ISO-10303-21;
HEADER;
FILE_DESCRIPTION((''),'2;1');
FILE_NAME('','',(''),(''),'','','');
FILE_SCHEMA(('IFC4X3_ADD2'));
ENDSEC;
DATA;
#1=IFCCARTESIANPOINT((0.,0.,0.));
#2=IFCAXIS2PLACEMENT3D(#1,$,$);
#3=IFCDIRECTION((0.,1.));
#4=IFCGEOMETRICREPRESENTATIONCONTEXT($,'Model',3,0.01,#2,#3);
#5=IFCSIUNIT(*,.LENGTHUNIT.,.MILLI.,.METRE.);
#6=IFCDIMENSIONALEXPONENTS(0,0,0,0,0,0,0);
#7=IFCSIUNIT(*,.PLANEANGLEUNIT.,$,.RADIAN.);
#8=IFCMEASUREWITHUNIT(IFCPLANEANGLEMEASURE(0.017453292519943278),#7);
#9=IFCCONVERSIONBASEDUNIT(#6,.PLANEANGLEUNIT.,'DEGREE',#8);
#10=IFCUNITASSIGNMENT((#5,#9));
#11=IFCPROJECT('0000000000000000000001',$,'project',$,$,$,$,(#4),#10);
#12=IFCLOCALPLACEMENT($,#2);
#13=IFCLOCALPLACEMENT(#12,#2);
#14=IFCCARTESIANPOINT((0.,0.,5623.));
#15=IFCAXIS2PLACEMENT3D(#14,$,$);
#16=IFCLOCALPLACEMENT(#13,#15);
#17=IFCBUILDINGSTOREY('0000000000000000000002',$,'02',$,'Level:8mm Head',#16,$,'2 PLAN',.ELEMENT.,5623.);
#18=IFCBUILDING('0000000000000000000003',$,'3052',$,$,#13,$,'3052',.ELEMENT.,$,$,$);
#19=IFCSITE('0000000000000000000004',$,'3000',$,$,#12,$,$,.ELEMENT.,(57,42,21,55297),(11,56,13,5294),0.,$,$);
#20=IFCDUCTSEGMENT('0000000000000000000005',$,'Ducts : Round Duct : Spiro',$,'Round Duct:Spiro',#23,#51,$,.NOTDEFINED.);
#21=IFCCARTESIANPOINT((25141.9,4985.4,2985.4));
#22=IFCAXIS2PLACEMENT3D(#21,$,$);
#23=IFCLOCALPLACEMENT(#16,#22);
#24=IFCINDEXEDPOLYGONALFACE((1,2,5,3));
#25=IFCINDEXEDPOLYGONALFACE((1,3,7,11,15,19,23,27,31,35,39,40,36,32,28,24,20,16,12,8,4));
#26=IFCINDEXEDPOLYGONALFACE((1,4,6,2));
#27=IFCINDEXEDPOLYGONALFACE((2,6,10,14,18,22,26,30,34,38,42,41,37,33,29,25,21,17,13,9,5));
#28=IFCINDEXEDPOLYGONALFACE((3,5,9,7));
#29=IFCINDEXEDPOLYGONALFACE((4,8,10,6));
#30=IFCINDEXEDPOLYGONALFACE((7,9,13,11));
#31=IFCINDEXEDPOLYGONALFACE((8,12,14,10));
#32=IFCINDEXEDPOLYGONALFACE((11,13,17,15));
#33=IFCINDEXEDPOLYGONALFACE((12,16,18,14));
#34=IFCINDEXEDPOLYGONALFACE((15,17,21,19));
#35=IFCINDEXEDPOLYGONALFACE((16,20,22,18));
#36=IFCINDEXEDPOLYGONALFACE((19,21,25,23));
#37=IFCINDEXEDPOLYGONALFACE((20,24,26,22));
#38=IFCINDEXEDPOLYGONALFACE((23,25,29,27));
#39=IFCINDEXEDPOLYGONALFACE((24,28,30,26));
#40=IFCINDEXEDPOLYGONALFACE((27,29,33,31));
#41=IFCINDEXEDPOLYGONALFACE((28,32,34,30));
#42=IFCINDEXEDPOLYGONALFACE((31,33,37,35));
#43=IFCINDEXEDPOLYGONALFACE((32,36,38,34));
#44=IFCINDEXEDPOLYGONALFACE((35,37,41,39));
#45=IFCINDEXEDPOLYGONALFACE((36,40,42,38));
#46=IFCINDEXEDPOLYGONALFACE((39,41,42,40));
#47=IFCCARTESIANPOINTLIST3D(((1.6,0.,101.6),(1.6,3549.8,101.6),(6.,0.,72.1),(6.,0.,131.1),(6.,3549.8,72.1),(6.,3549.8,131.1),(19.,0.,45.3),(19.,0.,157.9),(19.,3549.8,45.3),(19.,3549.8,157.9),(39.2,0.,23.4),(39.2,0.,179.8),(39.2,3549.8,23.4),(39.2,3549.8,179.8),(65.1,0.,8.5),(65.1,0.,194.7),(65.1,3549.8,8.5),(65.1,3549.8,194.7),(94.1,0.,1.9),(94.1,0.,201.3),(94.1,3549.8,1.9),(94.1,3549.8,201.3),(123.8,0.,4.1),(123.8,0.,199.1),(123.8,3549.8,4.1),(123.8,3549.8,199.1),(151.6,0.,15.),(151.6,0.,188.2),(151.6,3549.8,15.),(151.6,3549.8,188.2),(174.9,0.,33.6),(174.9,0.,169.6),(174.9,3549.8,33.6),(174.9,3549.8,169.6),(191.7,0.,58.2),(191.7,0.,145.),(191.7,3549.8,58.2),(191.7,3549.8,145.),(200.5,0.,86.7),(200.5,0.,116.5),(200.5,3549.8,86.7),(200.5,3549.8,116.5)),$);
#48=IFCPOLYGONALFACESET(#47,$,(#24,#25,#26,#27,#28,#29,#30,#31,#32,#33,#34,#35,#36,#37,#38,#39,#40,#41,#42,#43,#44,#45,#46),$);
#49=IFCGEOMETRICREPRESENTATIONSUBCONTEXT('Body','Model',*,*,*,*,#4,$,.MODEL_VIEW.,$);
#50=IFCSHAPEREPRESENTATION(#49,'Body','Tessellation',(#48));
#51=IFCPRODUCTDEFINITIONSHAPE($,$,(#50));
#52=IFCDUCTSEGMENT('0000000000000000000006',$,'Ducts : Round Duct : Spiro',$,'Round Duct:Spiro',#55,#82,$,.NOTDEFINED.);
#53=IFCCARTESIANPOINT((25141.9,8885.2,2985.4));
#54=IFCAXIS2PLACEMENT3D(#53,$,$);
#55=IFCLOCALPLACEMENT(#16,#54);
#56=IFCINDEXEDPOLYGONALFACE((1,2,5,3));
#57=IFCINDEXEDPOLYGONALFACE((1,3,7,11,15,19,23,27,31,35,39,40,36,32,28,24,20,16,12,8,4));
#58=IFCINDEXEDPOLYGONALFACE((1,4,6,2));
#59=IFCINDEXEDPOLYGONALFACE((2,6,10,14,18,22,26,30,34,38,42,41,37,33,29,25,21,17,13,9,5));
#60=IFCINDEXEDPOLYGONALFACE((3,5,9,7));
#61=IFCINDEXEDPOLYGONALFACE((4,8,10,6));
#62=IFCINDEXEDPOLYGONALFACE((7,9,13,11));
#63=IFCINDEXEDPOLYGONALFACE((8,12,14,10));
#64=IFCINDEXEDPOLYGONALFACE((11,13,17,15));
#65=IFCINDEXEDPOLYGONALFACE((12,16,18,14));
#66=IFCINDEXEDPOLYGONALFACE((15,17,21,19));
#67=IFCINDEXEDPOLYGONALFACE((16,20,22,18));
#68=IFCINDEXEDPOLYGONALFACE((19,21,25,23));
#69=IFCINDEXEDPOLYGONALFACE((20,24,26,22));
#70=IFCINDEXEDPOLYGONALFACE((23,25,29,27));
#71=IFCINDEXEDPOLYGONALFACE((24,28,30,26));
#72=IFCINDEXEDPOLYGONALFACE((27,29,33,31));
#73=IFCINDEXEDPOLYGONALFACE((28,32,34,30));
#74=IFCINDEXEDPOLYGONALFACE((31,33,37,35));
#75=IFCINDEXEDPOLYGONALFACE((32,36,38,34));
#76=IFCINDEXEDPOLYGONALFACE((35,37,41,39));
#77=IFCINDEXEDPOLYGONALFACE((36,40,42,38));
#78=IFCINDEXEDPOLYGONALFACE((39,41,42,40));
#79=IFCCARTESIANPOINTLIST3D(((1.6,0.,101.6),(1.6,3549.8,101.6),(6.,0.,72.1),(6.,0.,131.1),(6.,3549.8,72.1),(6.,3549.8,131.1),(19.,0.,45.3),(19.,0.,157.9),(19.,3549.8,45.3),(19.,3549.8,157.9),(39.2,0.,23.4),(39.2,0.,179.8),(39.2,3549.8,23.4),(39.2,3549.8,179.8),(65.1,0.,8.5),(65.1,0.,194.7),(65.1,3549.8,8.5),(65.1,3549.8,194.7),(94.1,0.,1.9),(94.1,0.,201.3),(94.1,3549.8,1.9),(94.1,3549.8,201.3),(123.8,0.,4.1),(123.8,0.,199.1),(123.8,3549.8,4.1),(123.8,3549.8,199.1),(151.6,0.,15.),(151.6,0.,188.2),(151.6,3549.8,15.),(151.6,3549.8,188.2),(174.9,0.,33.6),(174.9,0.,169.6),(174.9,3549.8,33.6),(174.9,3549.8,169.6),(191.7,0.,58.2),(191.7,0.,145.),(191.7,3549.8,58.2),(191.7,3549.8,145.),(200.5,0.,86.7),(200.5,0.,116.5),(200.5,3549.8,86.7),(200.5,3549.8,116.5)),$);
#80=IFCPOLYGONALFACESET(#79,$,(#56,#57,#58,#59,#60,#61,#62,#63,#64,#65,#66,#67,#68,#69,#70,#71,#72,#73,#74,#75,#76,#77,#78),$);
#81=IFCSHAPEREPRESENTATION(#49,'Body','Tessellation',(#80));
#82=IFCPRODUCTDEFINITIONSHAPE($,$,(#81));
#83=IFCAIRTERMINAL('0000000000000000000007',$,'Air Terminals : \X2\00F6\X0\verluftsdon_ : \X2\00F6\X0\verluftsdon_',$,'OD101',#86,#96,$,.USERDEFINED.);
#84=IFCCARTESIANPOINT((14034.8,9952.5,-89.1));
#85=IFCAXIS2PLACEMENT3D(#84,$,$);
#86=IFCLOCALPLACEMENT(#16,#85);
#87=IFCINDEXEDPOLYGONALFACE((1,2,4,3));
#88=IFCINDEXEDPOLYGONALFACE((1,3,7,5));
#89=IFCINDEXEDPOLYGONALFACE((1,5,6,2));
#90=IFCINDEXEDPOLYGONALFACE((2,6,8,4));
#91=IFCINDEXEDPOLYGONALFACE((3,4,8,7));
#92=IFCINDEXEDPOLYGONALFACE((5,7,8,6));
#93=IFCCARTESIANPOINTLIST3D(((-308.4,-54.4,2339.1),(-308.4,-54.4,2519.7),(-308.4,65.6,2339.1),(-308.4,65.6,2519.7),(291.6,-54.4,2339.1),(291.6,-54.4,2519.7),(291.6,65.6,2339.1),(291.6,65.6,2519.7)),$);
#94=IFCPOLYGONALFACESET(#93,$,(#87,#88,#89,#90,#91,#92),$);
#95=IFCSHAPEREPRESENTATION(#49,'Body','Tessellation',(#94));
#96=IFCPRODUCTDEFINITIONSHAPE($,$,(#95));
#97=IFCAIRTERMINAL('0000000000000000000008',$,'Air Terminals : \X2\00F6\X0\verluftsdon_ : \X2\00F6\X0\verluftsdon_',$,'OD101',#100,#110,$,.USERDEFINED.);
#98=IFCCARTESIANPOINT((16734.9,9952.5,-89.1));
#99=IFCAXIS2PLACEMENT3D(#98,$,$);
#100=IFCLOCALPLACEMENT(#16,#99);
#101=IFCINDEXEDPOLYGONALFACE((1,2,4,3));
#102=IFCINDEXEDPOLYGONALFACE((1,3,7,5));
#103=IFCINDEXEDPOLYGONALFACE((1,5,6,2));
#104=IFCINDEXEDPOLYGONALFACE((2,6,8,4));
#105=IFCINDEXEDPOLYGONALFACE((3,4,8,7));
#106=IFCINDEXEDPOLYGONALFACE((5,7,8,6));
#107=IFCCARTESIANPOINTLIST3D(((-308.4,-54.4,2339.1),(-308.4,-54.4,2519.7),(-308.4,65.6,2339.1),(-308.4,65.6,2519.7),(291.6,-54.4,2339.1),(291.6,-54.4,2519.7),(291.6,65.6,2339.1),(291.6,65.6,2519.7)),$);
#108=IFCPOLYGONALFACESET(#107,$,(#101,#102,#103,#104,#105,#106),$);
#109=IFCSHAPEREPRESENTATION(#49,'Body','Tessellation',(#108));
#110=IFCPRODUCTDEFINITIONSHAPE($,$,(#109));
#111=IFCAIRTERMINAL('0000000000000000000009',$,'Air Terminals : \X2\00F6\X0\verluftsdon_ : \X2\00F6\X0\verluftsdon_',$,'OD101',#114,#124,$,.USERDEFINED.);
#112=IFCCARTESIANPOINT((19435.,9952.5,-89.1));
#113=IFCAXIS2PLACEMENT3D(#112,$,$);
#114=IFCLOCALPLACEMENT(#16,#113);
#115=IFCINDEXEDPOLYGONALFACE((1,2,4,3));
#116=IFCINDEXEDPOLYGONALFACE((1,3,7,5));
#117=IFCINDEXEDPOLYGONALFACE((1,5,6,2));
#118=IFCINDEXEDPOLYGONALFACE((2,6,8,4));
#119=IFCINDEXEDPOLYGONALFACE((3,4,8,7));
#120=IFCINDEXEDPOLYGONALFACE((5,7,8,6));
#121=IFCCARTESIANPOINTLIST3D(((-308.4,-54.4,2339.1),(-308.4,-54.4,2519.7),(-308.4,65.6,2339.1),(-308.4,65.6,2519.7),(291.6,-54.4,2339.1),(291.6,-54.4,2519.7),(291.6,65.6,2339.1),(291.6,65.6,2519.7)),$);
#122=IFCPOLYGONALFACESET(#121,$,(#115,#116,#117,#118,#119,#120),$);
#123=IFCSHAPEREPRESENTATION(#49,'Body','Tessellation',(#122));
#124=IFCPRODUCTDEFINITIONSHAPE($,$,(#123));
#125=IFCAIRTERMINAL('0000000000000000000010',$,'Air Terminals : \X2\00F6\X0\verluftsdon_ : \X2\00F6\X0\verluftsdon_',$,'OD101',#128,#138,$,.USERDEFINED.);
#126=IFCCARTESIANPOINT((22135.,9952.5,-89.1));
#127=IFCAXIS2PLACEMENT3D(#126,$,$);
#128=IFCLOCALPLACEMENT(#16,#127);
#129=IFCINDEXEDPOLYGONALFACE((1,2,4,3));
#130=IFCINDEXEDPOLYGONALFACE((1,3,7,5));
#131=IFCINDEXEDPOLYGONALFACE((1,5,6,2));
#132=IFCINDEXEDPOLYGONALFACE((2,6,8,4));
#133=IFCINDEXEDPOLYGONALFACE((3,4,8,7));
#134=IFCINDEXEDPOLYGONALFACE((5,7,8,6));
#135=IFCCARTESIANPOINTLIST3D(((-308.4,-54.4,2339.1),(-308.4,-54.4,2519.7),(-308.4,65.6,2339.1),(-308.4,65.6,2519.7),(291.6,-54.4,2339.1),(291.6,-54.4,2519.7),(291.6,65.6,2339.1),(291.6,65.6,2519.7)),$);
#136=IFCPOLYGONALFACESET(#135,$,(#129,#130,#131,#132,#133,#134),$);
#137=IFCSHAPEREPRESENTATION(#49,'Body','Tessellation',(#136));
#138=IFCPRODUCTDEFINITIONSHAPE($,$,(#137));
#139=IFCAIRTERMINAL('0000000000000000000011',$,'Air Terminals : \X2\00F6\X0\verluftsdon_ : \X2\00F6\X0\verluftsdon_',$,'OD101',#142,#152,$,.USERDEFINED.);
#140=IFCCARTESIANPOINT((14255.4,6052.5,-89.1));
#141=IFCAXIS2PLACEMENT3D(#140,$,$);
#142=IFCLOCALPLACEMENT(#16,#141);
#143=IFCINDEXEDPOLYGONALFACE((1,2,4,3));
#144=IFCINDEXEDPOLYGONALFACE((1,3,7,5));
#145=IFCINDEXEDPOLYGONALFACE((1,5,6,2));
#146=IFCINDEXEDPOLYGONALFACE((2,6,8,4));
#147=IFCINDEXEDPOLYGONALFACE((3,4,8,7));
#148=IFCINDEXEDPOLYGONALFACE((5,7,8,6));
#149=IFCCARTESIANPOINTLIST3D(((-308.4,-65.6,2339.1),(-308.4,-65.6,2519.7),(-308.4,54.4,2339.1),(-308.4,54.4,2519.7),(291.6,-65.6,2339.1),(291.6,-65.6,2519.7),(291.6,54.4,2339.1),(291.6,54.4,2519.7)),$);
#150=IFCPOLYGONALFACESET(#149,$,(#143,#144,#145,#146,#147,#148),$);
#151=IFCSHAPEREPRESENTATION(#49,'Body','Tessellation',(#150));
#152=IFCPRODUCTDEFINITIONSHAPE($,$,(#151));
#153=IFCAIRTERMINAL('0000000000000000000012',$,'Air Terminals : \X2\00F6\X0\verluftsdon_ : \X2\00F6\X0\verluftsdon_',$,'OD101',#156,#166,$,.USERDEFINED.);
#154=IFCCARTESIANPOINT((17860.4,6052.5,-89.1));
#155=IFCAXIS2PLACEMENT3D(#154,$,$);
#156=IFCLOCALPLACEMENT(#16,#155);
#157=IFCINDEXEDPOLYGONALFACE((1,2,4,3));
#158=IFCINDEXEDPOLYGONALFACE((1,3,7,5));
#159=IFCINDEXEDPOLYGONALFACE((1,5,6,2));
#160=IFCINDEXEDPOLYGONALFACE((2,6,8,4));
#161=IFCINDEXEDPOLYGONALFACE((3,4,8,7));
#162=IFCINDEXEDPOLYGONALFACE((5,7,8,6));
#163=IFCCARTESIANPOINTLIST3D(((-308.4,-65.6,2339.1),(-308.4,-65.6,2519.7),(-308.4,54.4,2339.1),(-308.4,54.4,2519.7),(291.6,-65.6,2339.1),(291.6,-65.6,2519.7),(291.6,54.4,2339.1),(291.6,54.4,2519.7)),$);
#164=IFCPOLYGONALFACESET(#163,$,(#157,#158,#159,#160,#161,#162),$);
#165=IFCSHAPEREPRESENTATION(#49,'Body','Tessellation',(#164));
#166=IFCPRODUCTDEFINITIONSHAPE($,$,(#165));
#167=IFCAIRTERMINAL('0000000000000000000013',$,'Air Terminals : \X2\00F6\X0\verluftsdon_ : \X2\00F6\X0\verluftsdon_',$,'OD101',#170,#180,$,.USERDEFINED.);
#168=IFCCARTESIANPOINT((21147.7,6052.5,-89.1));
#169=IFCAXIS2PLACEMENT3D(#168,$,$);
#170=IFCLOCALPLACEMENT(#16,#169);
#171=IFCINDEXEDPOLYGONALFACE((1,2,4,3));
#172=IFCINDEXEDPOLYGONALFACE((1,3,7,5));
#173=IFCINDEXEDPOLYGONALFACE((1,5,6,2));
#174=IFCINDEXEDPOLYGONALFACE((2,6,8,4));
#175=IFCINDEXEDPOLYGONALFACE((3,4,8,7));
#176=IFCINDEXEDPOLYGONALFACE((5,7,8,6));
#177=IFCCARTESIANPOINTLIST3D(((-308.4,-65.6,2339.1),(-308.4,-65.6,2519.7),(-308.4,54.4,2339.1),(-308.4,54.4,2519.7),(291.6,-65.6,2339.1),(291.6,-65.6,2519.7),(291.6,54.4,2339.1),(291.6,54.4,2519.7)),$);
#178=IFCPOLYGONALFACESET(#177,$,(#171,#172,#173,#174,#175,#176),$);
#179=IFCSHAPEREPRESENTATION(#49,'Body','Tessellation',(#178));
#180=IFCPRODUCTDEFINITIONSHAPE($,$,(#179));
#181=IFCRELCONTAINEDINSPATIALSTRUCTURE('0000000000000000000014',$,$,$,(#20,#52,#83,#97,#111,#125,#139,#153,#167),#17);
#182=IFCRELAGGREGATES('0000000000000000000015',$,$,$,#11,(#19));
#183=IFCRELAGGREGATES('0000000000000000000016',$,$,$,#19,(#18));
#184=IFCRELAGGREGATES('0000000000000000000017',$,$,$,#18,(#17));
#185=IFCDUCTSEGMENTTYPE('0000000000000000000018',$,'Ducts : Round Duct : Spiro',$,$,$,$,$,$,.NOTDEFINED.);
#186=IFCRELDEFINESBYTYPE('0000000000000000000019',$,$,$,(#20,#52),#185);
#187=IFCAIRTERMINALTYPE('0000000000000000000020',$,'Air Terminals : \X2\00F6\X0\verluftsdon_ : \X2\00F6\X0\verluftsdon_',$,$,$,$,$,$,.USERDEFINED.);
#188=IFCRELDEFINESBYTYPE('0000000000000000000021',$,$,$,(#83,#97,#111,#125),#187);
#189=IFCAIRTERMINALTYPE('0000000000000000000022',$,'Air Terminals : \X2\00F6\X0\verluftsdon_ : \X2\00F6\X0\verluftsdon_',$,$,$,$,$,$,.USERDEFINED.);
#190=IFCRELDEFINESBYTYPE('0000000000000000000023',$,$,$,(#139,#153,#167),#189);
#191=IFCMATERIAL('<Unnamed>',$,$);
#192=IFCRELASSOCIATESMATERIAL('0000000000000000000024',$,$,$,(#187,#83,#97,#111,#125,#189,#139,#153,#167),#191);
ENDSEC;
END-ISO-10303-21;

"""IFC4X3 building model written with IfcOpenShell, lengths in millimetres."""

from ifc_helpers import new_model, entity, si_unit, converted_unit, direction, frame, frame_2d, origin, origin_2d_with_axis, place, context, subcontext, project, spatial, rectangle, circle, extrude, source, transform, mapped, material, type_object, type_shapes, element, save


model = new_model("IFC4X3")

# Units and contexts
model_context = context("Model", 3, precision=0.01, world=origin(), true_north=direction((0.0, 1.0)))
body_context = subcontext(model_context, "Body", "Model", "MODEL_VIEW")
ifc_project = project(units=[si_unit("LENGTHUNIT", "METRE", prefix="MILLI"), converted_unit("PLANEANGLEUNIT", "DEGREE", entity("IfcPlaneAngleMeasure", 0.017453292519943278), si_unit("PLANEANGLEUNIT", "RADIAN"), dimensions=[0, 0, 0, 0, 0, 0, 0])], contexts=[model_context])

# Site, building, storey
site_placement = place(None, origin())
site = spatial("IfcSite", under=ifc_project, at=site_placement, Name="3000", CompositionType="ELEMENT", RefLatitude=(57, 42, 21, 55297), RefLongitude=(11, 56, 13, 5294), RefElevation=0.0)
building_placement = place(site_placement, origin())
building = spatial("IfcBuilding", under=site, at=building_placement, Name="3052", LongName="3052", CompositionType="ELEMENT")
storey_placement = place(building_placement, frame((0.0, 0.0, 5623.0)))
storey = spatial("IfcBuildingStorey", under=building, at=storey_placement, Name="02", ObjectType="Level:8mm Head", LongName="2 PLAN", CompositionType="ELEMENT", Elevation=5623.0)

# Duct segments
duct_segment_type = type_object("IfcDuctSegmentType", Name="Ducts : Round Duct : Spiro", PredefinedType="NOTDEFINED")
duct_segment_1_placement = place(storey_placement, frame((25141.9, 4985.4, 2985.4)))
element("IfcDuctSegment", 1, at=duct_segment_1_placement, inside=storey, type_object=duct_segment_type, Name="Ducts : Round Duct : Spiro", ObjectType="Round Duct:Spiro", PredefinedType="NOTDEFINED", context=body_context, shape_type="SweptSolid", body=[
    extrude(circle(Radius=100.0, at=frame_2d((0.0, 0.0), x_axis=(1.0, 0.0))), frame((101.6, 0.0, 101.6), z_axis=(0.0, 1.0, 0.0), x_axis=(-1.0, 0.0, 0.0)), (0.0, 0.0, 1.0), 3549.8),
])
duct_segment_2_placement = place(storey_placement, frame((25141.9, 8885.2, 2985.4)))
element("IfcDuctSegment", 2, at=duct_segment_2_placement, inside=storey, type_object=duct_segment_type, Name="Ducts : Round Duct : Spiro", ObjectType="Round Duct:Spiro", PredefinedType="NOTDEFINED", context=body_context, shape_type="SweptSolid", body=[
    extrude(circle(Radius=100.0, at=frame_2d((0.0, 0.0), x_axis=(1.0, 0.0))), frame((101.6, 0.0, 101.6), z_axis=(0.0, 1.0, 0.0), x_axis=(-1.0, 0.0, 0.0)), (0.0, 0.0, 1.0), 3549.8),
])

# Air terminals
ifc_material_1 = material(Name="<Unnamed>")
air_terminal_type_1 = type_object("IfcAirTerminalType", Name="Air Terminals : överluftsdon_ : överluftsdon_", PredefinedType="USERDEFINED", material=ifc_material_1)
shared_shape_1 = source(origin(), body_context, "Body", "SweptSolid", [
    extrude(rectangle(XDim=600.0, YDim=120.0, at=origin_2d_with_axis()), frame((-8.4, 5.6, 2339.1), z_axis=(0.0, 0.0, 1.0), x_axis=(-1.0, 0.0, 0.0)), (0.0, 0.0, 1.0), 180.7),
])
type_shapes(air_terminal_type_1, [shared_shape_1])
for number, where, name in (
    (3, (14034.8, 9952.5, -89.1), "Air Terminals : överluftsdon_ : överluftsdon_"),
    (4, (16734.9, 9952.5, -89.1), "Air Terminals : överluftsdon_ : överluftsdon_"),
    (5, (19435.0, 9952.5, -89.1), "Air Terminals : överluftsdon_ : överluftsdon_"),
    (6, (22135.0, 9952.5, -89.1), "Air Terminals : överluftsdon_ : överluftsdon_"),
):
    element("IfcAirTerminal", number, at=place(storey_placement, frame(where)), inside=storey, type_object=air_terminal_type_1, material=ifc_material_1, Name=name, ObjectType="OD101", PredefinedType="USERDEFINED", context=body_context, shape_type="MappedRepresentation", body=[
        mapped(shared_shape_1, transform((0.0, 0.0, 0.0), scale=1.0)),
    ])
air_terminal_type_2 = type_object("IfcAirTerminalType", Name="Air Terminals : överluftsdon_ : överluftsdon_", PredefinedType="USERDEFINED", material=ifc_material_1)
shared_shape_2 = source(origin(), body_context, "Body", "SweptSolid", [
    extrude(rectangle(XDim=120.0, YDim=600.0, at=origin_2d_with_axis()), frame((-8.4, -5.6, 2339.1), z_axis=(0.0, 0.0, 1.0), x_axis=(0.0, 1.0, 0.0)), (0.0, 0.0, 1.0), 180.7),
])
type_shapes(air_terminal_type_2, [shared_shape_2])
for number, where, name in (
    (7, (14255.4, 6052.5, -89.1), "Air Terminals : överluftsdon_ : överluftsdon_"),
    (8, (17860.4, 6052.5, -89.1), "Air Terminals : överluftsdon_ : överluftsdon_"),
    (9, (21147.7, 6052.5, -89.1), "Air Terminals : överluftsdon_ : överluftsdon_"),
):
    element("IfcAirTerminal", number, at=place(storey_placement, frame(where)), inside=storey, type_object=air_terminal_type_2, material=ifc_material_1, Name=name, ObjectType="OD101", PredefinedType="USERDEFINED", context=body_context, shape_type="MappedRepresentation", body=[
        mapped(shared_shape_2, transform((0.0, 0.0, 0.0), scale=1.0)),
    ])

save(model, "model.ifc")
